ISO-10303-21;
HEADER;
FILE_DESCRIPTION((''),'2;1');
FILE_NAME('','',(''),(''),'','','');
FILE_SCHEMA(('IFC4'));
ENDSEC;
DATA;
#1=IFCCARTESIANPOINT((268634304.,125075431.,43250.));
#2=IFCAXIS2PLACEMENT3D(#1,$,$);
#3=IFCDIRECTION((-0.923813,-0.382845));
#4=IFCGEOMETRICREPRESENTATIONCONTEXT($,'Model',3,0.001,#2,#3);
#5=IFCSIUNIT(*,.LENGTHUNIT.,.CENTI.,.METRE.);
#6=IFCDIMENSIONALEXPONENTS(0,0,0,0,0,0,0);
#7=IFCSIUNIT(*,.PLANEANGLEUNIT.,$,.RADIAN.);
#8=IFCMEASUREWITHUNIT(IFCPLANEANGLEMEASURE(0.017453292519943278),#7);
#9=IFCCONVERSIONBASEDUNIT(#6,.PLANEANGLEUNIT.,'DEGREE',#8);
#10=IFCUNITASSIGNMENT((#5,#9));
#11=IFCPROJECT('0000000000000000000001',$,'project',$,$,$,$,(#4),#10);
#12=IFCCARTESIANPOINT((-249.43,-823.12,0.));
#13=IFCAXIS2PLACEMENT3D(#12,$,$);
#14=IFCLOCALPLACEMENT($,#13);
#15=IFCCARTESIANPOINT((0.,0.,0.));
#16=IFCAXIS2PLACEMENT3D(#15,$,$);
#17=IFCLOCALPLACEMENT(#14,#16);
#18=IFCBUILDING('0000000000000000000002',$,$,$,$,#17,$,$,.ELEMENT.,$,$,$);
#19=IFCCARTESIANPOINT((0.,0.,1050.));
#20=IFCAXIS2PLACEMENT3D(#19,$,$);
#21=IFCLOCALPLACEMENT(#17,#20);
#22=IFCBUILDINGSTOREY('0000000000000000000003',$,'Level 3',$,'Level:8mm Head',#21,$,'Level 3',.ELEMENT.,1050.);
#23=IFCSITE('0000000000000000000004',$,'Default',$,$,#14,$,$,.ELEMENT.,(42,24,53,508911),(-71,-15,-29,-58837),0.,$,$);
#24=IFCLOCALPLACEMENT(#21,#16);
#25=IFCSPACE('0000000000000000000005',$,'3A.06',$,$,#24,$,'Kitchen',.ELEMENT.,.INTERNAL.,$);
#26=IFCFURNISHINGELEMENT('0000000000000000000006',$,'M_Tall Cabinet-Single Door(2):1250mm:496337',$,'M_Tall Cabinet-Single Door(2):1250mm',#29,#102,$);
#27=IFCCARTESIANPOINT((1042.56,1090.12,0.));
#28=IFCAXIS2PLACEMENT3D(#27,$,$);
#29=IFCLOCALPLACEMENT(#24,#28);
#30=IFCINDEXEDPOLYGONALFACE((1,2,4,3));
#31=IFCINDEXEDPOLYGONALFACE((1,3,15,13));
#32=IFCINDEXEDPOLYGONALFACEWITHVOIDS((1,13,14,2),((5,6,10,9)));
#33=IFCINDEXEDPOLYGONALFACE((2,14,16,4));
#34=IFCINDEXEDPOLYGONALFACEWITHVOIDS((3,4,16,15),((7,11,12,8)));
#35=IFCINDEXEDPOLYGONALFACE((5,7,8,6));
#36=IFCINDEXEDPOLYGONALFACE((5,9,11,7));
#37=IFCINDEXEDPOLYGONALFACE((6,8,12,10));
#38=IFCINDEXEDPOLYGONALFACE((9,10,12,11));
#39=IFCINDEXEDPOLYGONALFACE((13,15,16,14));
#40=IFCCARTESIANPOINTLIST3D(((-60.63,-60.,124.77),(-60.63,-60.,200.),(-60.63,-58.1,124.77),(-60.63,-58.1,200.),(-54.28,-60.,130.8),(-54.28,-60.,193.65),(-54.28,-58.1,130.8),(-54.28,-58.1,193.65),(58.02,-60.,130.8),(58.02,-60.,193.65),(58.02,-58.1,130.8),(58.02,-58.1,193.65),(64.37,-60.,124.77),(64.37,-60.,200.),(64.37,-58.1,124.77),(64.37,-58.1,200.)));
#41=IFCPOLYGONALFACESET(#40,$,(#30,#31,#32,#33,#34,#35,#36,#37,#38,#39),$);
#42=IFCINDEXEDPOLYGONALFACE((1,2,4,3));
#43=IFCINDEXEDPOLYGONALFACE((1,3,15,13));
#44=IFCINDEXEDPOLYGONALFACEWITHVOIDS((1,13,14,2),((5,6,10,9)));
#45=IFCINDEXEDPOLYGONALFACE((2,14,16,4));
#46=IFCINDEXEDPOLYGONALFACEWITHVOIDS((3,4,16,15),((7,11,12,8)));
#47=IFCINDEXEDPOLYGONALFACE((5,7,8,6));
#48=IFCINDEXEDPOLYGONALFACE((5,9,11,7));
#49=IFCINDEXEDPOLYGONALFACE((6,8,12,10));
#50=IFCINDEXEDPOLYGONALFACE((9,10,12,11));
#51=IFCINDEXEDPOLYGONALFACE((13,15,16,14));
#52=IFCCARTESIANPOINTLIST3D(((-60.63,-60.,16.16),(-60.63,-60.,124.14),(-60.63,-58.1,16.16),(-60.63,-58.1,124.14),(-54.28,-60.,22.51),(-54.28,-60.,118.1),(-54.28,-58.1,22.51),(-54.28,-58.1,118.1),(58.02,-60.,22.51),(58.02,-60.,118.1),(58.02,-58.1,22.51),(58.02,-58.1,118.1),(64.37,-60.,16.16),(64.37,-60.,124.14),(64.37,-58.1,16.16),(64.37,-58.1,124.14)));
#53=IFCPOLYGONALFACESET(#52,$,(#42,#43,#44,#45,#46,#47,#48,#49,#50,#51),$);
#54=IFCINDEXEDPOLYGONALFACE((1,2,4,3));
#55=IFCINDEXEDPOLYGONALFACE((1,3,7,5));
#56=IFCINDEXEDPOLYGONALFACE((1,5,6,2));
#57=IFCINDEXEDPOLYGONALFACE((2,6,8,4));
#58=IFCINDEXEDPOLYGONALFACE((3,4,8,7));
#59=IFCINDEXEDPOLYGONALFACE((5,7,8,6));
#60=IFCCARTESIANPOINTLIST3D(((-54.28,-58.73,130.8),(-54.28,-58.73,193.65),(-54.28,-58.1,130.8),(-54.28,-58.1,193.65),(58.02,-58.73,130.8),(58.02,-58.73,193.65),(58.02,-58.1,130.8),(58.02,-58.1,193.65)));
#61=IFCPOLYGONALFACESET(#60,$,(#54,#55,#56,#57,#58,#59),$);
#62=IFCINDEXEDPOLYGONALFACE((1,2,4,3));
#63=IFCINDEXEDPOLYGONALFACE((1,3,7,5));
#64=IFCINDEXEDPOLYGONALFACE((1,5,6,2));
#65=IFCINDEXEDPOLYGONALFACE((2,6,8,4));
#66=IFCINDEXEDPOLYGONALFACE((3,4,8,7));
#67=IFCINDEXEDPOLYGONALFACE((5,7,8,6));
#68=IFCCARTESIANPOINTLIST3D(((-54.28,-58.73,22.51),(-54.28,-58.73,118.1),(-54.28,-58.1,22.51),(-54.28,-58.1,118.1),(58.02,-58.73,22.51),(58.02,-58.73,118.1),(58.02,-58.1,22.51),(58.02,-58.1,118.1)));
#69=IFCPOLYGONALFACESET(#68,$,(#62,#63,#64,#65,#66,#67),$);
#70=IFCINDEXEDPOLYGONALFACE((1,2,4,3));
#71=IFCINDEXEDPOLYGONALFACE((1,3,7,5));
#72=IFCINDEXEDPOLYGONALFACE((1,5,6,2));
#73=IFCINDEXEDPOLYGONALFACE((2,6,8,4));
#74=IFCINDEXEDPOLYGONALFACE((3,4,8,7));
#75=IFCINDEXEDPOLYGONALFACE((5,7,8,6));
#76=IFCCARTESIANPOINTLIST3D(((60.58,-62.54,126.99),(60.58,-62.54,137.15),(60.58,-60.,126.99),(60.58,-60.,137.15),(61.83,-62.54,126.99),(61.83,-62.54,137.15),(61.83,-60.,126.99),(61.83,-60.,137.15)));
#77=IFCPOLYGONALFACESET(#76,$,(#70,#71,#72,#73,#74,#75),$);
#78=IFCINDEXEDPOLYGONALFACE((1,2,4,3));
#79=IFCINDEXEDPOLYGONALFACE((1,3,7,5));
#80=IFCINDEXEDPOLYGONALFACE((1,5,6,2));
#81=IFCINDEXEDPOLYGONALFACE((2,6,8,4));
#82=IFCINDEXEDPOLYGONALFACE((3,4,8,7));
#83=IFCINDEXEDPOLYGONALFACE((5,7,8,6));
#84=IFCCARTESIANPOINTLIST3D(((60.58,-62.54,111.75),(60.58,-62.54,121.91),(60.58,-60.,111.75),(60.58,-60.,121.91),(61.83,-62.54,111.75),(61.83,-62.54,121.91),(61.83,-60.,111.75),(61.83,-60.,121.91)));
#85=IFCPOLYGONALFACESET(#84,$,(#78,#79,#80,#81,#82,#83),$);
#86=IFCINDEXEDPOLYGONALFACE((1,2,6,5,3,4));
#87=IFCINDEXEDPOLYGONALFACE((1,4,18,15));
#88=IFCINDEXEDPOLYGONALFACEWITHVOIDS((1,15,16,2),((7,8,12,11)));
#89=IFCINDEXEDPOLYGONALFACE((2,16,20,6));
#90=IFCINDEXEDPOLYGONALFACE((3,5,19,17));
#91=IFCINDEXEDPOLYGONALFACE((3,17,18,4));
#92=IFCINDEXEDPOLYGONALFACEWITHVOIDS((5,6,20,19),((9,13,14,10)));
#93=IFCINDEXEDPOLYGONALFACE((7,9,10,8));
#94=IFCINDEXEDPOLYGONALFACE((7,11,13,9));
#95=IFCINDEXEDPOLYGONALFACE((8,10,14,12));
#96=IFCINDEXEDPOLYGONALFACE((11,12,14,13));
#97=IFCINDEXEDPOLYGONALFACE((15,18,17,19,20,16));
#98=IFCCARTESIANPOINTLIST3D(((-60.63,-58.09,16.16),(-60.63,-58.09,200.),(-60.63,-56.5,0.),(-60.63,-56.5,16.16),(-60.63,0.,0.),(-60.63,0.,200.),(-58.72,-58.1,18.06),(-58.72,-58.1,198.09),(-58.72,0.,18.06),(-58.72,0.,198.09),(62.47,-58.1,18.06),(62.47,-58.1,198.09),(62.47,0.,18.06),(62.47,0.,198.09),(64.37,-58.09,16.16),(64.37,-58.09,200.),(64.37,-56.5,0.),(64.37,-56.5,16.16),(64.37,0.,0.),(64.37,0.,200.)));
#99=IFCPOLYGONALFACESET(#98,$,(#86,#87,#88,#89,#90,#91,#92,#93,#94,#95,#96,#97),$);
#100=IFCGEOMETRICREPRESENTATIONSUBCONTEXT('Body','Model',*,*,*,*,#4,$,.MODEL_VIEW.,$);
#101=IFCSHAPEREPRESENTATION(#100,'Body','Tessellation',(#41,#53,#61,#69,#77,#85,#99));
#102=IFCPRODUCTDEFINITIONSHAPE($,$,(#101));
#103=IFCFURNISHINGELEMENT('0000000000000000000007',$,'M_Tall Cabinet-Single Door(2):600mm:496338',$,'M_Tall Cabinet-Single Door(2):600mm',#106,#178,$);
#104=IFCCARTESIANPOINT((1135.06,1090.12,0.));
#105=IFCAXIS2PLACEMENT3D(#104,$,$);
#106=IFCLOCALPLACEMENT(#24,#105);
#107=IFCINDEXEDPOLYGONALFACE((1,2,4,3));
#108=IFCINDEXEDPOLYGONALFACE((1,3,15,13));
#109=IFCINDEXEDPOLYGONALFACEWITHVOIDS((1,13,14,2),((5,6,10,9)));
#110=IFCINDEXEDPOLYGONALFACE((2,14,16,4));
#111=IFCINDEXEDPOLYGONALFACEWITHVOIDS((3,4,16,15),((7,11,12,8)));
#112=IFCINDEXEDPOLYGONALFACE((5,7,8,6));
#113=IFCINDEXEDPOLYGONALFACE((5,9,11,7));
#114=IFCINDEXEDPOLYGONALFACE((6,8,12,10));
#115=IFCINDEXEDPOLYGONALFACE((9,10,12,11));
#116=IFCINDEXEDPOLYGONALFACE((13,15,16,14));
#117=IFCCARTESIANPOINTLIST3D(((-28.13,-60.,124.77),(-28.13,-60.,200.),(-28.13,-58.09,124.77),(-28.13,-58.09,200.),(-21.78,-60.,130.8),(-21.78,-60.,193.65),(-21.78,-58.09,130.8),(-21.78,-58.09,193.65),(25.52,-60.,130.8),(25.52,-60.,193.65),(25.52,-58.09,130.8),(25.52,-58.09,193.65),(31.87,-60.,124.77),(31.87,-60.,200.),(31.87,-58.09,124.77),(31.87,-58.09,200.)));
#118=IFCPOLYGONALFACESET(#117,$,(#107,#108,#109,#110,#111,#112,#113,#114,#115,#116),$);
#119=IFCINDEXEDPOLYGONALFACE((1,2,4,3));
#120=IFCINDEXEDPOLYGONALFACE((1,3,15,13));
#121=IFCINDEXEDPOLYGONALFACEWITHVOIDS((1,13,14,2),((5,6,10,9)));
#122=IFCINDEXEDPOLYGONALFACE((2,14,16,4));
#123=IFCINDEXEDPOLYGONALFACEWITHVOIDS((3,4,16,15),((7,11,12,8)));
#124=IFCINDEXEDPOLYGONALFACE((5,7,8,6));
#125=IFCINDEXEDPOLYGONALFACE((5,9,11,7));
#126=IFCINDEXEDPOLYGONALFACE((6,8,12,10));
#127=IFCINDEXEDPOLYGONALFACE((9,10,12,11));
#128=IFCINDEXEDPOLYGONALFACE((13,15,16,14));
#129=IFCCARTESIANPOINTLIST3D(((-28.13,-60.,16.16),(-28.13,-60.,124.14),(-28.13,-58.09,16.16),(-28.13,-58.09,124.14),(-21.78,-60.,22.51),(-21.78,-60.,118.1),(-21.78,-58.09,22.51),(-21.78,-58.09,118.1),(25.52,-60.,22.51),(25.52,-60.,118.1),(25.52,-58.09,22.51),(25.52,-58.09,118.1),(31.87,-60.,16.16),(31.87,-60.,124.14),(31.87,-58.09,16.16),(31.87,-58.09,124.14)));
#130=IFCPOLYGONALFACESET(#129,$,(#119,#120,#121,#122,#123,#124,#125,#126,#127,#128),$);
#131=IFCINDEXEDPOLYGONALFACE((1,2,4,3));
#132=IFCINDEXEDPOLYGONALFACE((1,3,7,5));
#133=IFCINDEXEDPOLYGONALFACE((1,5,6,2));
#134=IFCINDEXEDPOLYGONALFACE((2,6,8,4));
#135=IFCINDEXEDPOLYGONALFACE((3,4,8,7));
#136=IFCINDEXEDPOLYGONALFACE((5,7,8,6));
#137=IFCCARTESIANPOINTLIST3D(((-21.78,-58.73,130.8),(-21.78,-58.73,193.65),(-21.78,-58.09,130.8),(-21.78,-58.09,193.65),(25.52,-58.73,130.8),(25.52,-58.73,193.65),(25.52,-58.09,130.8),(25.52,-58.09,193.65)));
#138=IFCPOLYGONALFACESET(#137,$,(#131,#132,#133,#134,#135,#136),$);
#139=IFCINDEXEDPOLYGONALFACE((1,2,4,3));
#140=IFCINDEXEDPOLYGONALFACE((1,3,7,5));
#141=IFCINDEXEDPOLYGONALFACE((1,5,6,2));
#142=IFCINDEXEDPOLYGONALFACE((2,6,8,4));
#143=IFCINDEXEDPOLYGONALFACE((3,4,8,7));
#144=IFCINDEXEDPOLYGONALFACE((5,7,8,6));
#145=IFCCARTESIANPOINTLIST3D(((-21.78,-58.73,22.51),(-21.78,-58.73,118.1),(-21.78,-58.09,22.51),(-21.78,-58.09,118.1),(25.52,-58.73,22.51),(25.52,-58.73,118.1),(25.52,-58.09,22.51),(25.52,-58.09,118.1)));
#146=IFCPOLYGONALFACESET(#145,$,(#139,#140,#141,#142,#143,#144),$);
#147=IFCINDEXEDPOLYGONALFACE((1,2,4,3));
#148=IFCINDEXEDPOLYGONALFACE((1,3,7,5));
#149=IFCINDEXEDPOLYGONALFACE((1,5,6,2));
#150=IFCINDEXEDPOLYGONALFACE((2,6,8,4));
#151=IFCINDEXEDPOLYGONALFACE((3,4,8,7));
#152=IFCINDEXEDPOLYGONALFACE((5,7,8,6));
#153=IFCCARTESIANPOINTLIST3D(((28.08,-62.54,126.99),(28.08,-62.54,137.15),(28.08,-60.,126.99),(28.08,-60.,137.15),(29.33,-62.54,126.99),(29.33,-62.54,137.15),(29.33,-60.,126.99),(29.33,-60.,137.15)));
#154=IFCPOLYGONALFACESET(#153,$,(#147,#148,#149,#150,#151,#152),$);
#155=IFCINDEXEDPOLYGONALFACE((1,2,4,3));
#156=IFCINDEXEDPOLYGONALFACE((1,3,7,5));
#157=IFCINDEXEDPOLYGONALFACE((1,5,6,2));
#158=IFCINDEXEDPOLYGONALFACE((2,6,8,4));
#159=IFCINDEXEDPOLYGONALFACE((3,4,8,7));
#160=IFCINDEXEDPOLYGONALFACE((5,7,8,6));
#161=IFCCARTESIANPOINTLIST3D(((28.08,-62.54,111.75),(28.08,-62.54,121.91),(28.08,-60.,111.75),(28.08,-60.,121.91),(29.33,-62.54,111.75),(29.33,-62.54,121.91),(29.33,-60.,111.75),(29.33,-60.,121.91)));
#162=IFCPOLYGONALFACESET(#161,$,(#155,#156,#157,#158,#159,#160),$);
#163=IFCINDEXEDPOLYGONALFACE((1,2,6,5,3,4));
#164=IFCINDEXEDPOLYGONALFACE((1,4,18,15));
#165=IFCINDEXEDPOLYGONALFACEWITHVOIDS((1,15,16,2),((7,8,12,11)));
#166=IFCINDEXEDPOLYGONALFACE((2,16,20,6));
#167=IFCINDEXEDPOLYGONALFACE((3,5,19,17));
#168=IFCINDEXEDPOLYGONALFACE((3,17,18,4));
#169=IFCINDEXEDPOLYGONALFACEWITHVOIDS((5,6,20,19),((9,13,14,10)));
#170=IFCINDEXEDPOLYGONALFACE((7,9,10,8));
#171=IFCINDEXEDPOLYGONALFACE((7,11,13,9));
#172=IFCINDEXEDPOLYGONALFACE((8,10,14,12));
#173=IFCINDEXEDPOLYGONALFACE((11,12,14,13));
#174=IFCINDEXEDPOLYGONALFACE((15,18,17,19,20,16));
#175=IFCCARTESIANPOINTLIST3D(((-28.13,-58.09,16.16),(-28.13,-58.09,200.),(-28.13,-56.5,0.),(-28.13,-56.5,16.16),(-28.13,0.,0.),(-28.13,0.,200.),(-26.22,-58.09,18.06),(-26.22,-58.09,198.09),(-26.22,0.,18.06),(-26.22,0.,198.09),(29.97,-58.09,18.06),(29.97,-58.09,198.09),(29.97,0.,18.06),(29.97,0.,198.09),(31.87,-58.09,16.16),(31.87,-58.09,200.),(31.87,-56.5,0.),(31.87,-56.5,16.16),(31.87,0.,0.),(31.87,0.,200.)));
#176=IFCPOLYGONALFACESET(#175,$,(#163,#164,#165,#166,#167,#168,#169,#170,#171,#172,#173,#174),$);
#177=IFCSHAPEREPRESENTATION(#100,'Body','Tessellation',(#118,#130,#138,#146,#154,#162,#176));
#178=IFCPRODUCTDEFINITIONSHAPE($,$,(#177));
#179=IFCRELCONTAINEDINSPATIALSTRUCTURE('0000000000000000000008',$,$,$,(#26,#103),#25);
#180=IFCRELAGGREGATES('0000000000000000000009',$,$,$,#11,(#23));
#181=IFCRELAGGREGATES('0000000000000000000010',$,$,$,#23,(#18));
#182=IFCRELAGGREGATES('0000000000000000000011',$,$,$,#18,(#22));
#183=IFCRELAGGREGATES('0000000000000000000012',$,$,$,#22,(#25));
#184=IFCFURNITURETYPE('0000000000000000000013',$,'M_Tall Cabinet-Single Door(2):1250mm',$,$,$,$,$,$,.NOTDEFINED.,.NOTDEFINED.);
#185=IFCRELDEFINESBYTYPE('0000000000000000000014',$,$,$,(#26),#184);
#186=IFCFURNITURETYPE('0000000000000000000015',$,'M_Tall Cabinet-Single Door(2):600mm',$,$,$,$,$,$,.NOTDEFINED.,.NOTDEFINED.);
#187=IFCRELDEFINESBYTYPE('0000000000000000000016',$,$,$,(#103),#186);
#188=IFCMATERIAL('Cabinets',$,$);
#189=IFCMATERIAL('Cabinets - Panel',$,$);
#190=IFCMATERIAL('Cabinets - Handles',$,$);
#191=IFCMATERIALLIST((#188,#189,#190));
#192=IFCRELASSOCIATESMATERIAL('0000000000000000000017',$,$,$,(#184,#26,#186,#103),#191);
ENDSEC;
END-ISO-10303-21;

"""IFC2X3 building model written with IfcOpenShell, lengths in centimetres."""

from ifc_helpers import new_model, entity, si_unit, converted_unit, direction, frame, frame_2d, origin, origin_2d_with_axis, place, context, subcontext, project, spatial, polyline, rectangle, outline, extrude, source, transform, mapped, material, material_list, type_object, type_shapes, element, save


model = new_model("IFC2X3")

# Units and contexts
model_context = context("Model", 3, precision=0.001, world=frame((268634304.0, 125075431.0, 43250.0)), true_north=direction((-0.923813, -0.382845)))
body_context = subcontext(model_context, "Body", "Model", "MODEL_VIEW")
ifc_project = project(units=[si_unit("LENGTHUNIT", "METRE", prefix="CENTI"), converted_unit("PLANEANGLEUNIT", "DEGREE", entity("IfcPlaneAngleMeasure", 0.017453292519943278), si_unit("PLANEANGLEUNIT", "RADIAN"), dimensions=[0, 0, 0, 0, 0, 0, 0])], contexts=[model_context])

# Site, building, storey
site_placement = place(None, frame((-249.43, -823.12, 0.0)))
site = spatial("IfcSite", under=ifc_project, at=site_placement, Name="Default", CompositionType="ELEMENT", RefLatitude=(42, 24, 53, 508911), RefLongitude=(-71, -15, -29, -58837), RefElevation=0.0)
building_placement = place(site_placement, origin())
building = spatial("IfcBuilding", under=site, at=building_placement, CompositionType="ELEMENT")
storey_placement = place(building_placement, frame((0.0, 0.0, 1050.0)))
storey = spatial("IfcBuildingStorey", under=building, at=storey_placement, Name="Level 3", ObjectType="Level:8mm Head", LongName="Level 3", CompositionType="ELEMENT", Elevation=1050.0)

# Shared definitions
space_1_placement = place(storey_placement, origin())
space_1 = spatial("IfcSpace", under=storey, at=space_1_placement, Name="3A.06", LongName="Kitchen", CompositionType="ELEMENT", InteriorOrExteriorSpace="INTERNAL")

# Furnishing elements, openings
ifc_material_1 = material(Name="Cabinets")
ifc_material_2 = material(Name="Cabinets - Panel")
ifc_material_3 = material(Name="Cabinets - Handles")
ifc_material_list_1 = material_list([ifc_material_1, ifc_material_2, ifc_material_3])
furniture_type_1 = type_object("IfcFurnitureType", Name="M_Tall Cabinet-Single Door(2):1250mm", AssemblyPlace="NOTDEFINED", material=ifc_material_list_1)
shared_shape_1 = source(origin(), body_context, "Body", "SweptSolid", [
    extrude(rectangle(XDim=1.91, YDim=121.19, at=origin_2d_with_axis()), frame((1.87, -0.95, 18.06), z_axis=(0.0, 0.0, 1.0), x_axis=(0.0, 1.0, 0.0)), (0.0, 0.0, 1.0), 180.03),
    extrude(outline(polyline([(-37.61, -62.5), (37.61, -62.5), (37.61, 62.5), (-37.61, 62.5), (-37.61, -62.5)]), holes=[polyline([(-31.26, -56.15), (-31.26, 56.15), (31.58, 56.15), (31.58, -56.15), (-31.26, -56.15)])]), frame((1.87, -60.0, 162.39), z_axis=(0.0, 1.0, 0.0), x_axis=(0.0, 0.0, -1.0)), (0.0, 0.0, 1.0), 1.91),
    extrude(outline(polyline([(-62.5, -53.99), (62.5, -53.99), (62.5, 53.99), (-62.5, 53.99), (-62.5, -53.99)]), holes=[polyline([(-56.15, 47.96), (56.15, 47.96), (56.15, -47.64), (-56.15, -47.64), (-56.15, 47.96)])]), frame((1.87, -60.0, 70.15), z_axis=(0.0, 1.0, 0.0), x_axis=(-1.0, 0.0, 0.0)), (0.0, 0.0, 1.0), 1.91),
    extrude(rectangle(XDim=0.63, YDim=112.3, at=frame_2d((0.0, 0.0), x_axis=(1.0, 0.0))), frame((1.87, -58.41, 130.8), z_axis=(0.0, 0.0, 1.0), x_axis=(0.0, 1.0, 0.0)), (0.0, 0.0, 1.0), 62.85),
    extrude(rectangle(XDim=0.63, YDim=112.3, at=frame_2d((0.0, 0.0), x_axis=(1.0, 0.0))), frame((1.87, -58.41, 22.51), z_axis=(0.0, 0.0, 1.0), x_axis=(0.0, 1.0, 0.0)), (0.0, 0.0, 1.0), 95.6),
    extrude(rectangle(XDim=2.54, YDim=1.25, at=frame_2d((0.0, 0.0), x_axis=(1.0, 0.0))), frame((61.21, -61.27, 126.99), z_axis=(0.0, 0.0, 1.0), x_axis=(0.0, 1.0, 0.0)), (0.0, 0.0, 1.0), 10.16),
    extrude(rectangle(XDim=2.54, YDim=1.25, at=frame_2d((0.0, 0.0), x_axis=(1.0, 0.0))), frame((61.21, -61.27, 111.75), z_axis=(0.0, 0.0, 1.0), x_axis=(0.0, 1.0, 0.0)), (0.0, 0.0, 1.0), 10.16),
    extrude(outline(polyline([(-19.9, 55.89), (-19.9, -127.95), (38.2, -127.95), (38.2, 72.05), (-18.3, 72.05), (-18.3, 55.89), (-19.9, 55.89)])), frame((-60.63, -38.2, 72.05), z_axis=(-1.0, 0.0, 0.0), x_axis=(0.0, 1.0, 0.0)), (0.0, 0.0, -1.0), 125.0),
])
type_shapes(furniture_type_1, [shared_shape_1])
furnishing_1_placement = place(space_1_placement, frame((1042.56, 1090.12, 0.0)))
furnishing_1 = element("IfcFurnishingElement", 1, at=furnishing_1_placement, inside=space_1, type_object=furniture_type_1, material=ifc_material_list_1, Name="M_Tall Cabinet-Single Door(2):1250mm:496337", ObjectType="M_Tall Cabinet-Single Door(2):1250mm", context=body_context, shape_type="MappedRepresentation", body=[
    mapped(shared_shape_1, transform((0.0, 0.0, 0.0), scale=1.0)),
])
opening_1_placement = place(storey_placement, frame((1042.56, 1090.12, 1050.0)))
element("IfcOpeningElement", 2, at=opening_1_placement, cuts=furnishing_1, ObjectType="Opening", context=body_context, shape_type="SweptSolid", body=[
    extrude(rectangle(XDim=180.03, YDim=121.19, at=frame_2d((0.0, 0.0), x_axis=(0.0, 1.0))), frame((1.87, 0.0, -941.92), z_axis=(0.0, -1.0, 0.0), x_axis=(-1.0, 0.0, 0.0)), (0.0, 0.0, 1.0), 58.09),
])
furniture_type_2 = type_object("IfcFurnitureType", Name="M_Tall Cabinet-Single Door(2):600mm", AssemblyPlace="NOTDEFINED", material=ifc_material_list_1)
shared_shape_2 = source(origin(), body_context, "Body", "SweptSolid", [
    extrude(rectangle(XDim=1.91, YDim=56.19, at=origin_2d_with_axis()), frame((1.87, -0.95, 18.06), z_axis=(0.0, 0.0, 1.0), x_axis=(0.0, 1.0, 0.0)), (0.0, 0.0, 1.0), 180.03),
    extrude(outline(polyline([(-37.61, -30.0), (37.61, -30.0), (37.61, 30.0), (-37.61, 30.0), (-37.61, -30.0)]), holes=[polyline([(-31.26, -23.65), (-31.26, 23.65), (31.58, 23.65), (31.58, -23.65), (-31.26, -23.65)])]), frame((1.87, -60.0, 162.39), z_axis=(0.0, 1.0, 0.0), x_axis=(0.0, 0.0, -1.0)), (0.0, 0.0, 1.0), 1.91),
    extrude(outline(polyline([(-30.0, -53.99), (30.0, -53.99), (30.0, 53.99), (-30.0, 53.99), (-30.0, -53.99)]), holes=[polyline([(-23.65, 47.96), (23.65, 47.96), (23.65, -47.64), (-23.65, -47.64), (-23.65, 47.96)])]), frame((1.87, -60.0, 70.15), z_axis=(0.0, 1.0, 0.0), x_axis=(-1.0, 0.0, 0.0)), (0.0, 0.0, 1.0), 1.91),
    extrude(rectangle(XDim=0.63, YDim=47.3, at=origin_2d_with_axis()), frame((1.87, -58.41, 130.8), z_axis=(0.0, 0.0, 1.0), x_axis=(0.0, 1.0, 0.0)), (0.0, 0.0, 1.0), 62.85),
    extrude(rectangle(XDim=0.63, YDim=47.3, at=origin_2d_with_axis()), frame((1.87, -58.41, 22.51), z_axis=(0.0, 0.0, 1.0), x_axis=(0.0, 1.0, 0.0)), (0.0, 0.0, 1.0), 95.6),
    extrude(rectangle(XDim=2.54, YDim=1.25, at=frame_2d((0.0, 0.0), x_axis=(1.0, 0.0))), frame((28.71, -61.27, 126.99), z_axis=(0.0, 0.0, 1.0), x_axis=(0.0, 1.0, 0.0)), (0.0, 0.0, 1.0), 10.16),
    extrude(rectangle(XDim=2.54, YDim=1.25, at=frame_2d((0.0, 0.0), x_axis=(1.0, 0.0))), frame((28.71, -61.27, 111.75), z_axis=(0.0, 0.0, 1.0), x_axis=(0.0, 1.0, 0.0)), (0.0, 0.0, 1.0), 10.16),
    extrude(outline(polyline([(-19.9, 55.89), (-19.9, -127.95), (38.2, -127.95), (38.2, 72.05), (-18.3, 72.05), (-18.3, 55.89), (-19.9, 55.89)])), frame((-28.13, -38.2, 72.05), z_axis=(-1.0, 0.0, 0.0), x_axis=(0.0, 1.0, 0.0)), (0.0, 0.0, -1.0), 60.0),
])
type_shapes(furniture_type_2, [shared_shape_2])
furnishing_2_placement = place(space_1_placement, frame((1135.06, 1090.12, 0.0)))
furnishing_2 = element("IfcFurnishingElement", 3, at=furnishing_2_placement, inside=space_1, type_object=furniture_type_2, material=ifc_material_list_1, Name="M_Tall Cabinet-Single Door(2):600mm:496338", ObjectType="M_Tall Cabinet-Single Door(2):600mm", context=body_context, shape_type="MappedRepresentation", body=[
    mapped(shared_shape_2, transform((0.0, 0.0, 0.0), scale=1.0)),
])
opening_2_placement = place(storey_placement, frame((1135.06, 1090.12, 1050.0)))
element("IfcOpeningElement", 4, at=opening_2_placement, cuts=furnishing_2, ObjectType="Opening", context=body_context, shape_type="SweptSolid", body=[
    extrude(rectangle(XDim=180.03, YDim=56.19, at=frame_2d((0.0, 0.0), x_axis=(0.0, 1.0))), frame((1.87, 0.0, -941.92), z_axis=(0.0, -1.0, 0.0), x_axis=(-1.0, 0.0, 0.0)), (0.0, 0.0, 1.0), 58.09),
])

save(model, "model.ifc")
